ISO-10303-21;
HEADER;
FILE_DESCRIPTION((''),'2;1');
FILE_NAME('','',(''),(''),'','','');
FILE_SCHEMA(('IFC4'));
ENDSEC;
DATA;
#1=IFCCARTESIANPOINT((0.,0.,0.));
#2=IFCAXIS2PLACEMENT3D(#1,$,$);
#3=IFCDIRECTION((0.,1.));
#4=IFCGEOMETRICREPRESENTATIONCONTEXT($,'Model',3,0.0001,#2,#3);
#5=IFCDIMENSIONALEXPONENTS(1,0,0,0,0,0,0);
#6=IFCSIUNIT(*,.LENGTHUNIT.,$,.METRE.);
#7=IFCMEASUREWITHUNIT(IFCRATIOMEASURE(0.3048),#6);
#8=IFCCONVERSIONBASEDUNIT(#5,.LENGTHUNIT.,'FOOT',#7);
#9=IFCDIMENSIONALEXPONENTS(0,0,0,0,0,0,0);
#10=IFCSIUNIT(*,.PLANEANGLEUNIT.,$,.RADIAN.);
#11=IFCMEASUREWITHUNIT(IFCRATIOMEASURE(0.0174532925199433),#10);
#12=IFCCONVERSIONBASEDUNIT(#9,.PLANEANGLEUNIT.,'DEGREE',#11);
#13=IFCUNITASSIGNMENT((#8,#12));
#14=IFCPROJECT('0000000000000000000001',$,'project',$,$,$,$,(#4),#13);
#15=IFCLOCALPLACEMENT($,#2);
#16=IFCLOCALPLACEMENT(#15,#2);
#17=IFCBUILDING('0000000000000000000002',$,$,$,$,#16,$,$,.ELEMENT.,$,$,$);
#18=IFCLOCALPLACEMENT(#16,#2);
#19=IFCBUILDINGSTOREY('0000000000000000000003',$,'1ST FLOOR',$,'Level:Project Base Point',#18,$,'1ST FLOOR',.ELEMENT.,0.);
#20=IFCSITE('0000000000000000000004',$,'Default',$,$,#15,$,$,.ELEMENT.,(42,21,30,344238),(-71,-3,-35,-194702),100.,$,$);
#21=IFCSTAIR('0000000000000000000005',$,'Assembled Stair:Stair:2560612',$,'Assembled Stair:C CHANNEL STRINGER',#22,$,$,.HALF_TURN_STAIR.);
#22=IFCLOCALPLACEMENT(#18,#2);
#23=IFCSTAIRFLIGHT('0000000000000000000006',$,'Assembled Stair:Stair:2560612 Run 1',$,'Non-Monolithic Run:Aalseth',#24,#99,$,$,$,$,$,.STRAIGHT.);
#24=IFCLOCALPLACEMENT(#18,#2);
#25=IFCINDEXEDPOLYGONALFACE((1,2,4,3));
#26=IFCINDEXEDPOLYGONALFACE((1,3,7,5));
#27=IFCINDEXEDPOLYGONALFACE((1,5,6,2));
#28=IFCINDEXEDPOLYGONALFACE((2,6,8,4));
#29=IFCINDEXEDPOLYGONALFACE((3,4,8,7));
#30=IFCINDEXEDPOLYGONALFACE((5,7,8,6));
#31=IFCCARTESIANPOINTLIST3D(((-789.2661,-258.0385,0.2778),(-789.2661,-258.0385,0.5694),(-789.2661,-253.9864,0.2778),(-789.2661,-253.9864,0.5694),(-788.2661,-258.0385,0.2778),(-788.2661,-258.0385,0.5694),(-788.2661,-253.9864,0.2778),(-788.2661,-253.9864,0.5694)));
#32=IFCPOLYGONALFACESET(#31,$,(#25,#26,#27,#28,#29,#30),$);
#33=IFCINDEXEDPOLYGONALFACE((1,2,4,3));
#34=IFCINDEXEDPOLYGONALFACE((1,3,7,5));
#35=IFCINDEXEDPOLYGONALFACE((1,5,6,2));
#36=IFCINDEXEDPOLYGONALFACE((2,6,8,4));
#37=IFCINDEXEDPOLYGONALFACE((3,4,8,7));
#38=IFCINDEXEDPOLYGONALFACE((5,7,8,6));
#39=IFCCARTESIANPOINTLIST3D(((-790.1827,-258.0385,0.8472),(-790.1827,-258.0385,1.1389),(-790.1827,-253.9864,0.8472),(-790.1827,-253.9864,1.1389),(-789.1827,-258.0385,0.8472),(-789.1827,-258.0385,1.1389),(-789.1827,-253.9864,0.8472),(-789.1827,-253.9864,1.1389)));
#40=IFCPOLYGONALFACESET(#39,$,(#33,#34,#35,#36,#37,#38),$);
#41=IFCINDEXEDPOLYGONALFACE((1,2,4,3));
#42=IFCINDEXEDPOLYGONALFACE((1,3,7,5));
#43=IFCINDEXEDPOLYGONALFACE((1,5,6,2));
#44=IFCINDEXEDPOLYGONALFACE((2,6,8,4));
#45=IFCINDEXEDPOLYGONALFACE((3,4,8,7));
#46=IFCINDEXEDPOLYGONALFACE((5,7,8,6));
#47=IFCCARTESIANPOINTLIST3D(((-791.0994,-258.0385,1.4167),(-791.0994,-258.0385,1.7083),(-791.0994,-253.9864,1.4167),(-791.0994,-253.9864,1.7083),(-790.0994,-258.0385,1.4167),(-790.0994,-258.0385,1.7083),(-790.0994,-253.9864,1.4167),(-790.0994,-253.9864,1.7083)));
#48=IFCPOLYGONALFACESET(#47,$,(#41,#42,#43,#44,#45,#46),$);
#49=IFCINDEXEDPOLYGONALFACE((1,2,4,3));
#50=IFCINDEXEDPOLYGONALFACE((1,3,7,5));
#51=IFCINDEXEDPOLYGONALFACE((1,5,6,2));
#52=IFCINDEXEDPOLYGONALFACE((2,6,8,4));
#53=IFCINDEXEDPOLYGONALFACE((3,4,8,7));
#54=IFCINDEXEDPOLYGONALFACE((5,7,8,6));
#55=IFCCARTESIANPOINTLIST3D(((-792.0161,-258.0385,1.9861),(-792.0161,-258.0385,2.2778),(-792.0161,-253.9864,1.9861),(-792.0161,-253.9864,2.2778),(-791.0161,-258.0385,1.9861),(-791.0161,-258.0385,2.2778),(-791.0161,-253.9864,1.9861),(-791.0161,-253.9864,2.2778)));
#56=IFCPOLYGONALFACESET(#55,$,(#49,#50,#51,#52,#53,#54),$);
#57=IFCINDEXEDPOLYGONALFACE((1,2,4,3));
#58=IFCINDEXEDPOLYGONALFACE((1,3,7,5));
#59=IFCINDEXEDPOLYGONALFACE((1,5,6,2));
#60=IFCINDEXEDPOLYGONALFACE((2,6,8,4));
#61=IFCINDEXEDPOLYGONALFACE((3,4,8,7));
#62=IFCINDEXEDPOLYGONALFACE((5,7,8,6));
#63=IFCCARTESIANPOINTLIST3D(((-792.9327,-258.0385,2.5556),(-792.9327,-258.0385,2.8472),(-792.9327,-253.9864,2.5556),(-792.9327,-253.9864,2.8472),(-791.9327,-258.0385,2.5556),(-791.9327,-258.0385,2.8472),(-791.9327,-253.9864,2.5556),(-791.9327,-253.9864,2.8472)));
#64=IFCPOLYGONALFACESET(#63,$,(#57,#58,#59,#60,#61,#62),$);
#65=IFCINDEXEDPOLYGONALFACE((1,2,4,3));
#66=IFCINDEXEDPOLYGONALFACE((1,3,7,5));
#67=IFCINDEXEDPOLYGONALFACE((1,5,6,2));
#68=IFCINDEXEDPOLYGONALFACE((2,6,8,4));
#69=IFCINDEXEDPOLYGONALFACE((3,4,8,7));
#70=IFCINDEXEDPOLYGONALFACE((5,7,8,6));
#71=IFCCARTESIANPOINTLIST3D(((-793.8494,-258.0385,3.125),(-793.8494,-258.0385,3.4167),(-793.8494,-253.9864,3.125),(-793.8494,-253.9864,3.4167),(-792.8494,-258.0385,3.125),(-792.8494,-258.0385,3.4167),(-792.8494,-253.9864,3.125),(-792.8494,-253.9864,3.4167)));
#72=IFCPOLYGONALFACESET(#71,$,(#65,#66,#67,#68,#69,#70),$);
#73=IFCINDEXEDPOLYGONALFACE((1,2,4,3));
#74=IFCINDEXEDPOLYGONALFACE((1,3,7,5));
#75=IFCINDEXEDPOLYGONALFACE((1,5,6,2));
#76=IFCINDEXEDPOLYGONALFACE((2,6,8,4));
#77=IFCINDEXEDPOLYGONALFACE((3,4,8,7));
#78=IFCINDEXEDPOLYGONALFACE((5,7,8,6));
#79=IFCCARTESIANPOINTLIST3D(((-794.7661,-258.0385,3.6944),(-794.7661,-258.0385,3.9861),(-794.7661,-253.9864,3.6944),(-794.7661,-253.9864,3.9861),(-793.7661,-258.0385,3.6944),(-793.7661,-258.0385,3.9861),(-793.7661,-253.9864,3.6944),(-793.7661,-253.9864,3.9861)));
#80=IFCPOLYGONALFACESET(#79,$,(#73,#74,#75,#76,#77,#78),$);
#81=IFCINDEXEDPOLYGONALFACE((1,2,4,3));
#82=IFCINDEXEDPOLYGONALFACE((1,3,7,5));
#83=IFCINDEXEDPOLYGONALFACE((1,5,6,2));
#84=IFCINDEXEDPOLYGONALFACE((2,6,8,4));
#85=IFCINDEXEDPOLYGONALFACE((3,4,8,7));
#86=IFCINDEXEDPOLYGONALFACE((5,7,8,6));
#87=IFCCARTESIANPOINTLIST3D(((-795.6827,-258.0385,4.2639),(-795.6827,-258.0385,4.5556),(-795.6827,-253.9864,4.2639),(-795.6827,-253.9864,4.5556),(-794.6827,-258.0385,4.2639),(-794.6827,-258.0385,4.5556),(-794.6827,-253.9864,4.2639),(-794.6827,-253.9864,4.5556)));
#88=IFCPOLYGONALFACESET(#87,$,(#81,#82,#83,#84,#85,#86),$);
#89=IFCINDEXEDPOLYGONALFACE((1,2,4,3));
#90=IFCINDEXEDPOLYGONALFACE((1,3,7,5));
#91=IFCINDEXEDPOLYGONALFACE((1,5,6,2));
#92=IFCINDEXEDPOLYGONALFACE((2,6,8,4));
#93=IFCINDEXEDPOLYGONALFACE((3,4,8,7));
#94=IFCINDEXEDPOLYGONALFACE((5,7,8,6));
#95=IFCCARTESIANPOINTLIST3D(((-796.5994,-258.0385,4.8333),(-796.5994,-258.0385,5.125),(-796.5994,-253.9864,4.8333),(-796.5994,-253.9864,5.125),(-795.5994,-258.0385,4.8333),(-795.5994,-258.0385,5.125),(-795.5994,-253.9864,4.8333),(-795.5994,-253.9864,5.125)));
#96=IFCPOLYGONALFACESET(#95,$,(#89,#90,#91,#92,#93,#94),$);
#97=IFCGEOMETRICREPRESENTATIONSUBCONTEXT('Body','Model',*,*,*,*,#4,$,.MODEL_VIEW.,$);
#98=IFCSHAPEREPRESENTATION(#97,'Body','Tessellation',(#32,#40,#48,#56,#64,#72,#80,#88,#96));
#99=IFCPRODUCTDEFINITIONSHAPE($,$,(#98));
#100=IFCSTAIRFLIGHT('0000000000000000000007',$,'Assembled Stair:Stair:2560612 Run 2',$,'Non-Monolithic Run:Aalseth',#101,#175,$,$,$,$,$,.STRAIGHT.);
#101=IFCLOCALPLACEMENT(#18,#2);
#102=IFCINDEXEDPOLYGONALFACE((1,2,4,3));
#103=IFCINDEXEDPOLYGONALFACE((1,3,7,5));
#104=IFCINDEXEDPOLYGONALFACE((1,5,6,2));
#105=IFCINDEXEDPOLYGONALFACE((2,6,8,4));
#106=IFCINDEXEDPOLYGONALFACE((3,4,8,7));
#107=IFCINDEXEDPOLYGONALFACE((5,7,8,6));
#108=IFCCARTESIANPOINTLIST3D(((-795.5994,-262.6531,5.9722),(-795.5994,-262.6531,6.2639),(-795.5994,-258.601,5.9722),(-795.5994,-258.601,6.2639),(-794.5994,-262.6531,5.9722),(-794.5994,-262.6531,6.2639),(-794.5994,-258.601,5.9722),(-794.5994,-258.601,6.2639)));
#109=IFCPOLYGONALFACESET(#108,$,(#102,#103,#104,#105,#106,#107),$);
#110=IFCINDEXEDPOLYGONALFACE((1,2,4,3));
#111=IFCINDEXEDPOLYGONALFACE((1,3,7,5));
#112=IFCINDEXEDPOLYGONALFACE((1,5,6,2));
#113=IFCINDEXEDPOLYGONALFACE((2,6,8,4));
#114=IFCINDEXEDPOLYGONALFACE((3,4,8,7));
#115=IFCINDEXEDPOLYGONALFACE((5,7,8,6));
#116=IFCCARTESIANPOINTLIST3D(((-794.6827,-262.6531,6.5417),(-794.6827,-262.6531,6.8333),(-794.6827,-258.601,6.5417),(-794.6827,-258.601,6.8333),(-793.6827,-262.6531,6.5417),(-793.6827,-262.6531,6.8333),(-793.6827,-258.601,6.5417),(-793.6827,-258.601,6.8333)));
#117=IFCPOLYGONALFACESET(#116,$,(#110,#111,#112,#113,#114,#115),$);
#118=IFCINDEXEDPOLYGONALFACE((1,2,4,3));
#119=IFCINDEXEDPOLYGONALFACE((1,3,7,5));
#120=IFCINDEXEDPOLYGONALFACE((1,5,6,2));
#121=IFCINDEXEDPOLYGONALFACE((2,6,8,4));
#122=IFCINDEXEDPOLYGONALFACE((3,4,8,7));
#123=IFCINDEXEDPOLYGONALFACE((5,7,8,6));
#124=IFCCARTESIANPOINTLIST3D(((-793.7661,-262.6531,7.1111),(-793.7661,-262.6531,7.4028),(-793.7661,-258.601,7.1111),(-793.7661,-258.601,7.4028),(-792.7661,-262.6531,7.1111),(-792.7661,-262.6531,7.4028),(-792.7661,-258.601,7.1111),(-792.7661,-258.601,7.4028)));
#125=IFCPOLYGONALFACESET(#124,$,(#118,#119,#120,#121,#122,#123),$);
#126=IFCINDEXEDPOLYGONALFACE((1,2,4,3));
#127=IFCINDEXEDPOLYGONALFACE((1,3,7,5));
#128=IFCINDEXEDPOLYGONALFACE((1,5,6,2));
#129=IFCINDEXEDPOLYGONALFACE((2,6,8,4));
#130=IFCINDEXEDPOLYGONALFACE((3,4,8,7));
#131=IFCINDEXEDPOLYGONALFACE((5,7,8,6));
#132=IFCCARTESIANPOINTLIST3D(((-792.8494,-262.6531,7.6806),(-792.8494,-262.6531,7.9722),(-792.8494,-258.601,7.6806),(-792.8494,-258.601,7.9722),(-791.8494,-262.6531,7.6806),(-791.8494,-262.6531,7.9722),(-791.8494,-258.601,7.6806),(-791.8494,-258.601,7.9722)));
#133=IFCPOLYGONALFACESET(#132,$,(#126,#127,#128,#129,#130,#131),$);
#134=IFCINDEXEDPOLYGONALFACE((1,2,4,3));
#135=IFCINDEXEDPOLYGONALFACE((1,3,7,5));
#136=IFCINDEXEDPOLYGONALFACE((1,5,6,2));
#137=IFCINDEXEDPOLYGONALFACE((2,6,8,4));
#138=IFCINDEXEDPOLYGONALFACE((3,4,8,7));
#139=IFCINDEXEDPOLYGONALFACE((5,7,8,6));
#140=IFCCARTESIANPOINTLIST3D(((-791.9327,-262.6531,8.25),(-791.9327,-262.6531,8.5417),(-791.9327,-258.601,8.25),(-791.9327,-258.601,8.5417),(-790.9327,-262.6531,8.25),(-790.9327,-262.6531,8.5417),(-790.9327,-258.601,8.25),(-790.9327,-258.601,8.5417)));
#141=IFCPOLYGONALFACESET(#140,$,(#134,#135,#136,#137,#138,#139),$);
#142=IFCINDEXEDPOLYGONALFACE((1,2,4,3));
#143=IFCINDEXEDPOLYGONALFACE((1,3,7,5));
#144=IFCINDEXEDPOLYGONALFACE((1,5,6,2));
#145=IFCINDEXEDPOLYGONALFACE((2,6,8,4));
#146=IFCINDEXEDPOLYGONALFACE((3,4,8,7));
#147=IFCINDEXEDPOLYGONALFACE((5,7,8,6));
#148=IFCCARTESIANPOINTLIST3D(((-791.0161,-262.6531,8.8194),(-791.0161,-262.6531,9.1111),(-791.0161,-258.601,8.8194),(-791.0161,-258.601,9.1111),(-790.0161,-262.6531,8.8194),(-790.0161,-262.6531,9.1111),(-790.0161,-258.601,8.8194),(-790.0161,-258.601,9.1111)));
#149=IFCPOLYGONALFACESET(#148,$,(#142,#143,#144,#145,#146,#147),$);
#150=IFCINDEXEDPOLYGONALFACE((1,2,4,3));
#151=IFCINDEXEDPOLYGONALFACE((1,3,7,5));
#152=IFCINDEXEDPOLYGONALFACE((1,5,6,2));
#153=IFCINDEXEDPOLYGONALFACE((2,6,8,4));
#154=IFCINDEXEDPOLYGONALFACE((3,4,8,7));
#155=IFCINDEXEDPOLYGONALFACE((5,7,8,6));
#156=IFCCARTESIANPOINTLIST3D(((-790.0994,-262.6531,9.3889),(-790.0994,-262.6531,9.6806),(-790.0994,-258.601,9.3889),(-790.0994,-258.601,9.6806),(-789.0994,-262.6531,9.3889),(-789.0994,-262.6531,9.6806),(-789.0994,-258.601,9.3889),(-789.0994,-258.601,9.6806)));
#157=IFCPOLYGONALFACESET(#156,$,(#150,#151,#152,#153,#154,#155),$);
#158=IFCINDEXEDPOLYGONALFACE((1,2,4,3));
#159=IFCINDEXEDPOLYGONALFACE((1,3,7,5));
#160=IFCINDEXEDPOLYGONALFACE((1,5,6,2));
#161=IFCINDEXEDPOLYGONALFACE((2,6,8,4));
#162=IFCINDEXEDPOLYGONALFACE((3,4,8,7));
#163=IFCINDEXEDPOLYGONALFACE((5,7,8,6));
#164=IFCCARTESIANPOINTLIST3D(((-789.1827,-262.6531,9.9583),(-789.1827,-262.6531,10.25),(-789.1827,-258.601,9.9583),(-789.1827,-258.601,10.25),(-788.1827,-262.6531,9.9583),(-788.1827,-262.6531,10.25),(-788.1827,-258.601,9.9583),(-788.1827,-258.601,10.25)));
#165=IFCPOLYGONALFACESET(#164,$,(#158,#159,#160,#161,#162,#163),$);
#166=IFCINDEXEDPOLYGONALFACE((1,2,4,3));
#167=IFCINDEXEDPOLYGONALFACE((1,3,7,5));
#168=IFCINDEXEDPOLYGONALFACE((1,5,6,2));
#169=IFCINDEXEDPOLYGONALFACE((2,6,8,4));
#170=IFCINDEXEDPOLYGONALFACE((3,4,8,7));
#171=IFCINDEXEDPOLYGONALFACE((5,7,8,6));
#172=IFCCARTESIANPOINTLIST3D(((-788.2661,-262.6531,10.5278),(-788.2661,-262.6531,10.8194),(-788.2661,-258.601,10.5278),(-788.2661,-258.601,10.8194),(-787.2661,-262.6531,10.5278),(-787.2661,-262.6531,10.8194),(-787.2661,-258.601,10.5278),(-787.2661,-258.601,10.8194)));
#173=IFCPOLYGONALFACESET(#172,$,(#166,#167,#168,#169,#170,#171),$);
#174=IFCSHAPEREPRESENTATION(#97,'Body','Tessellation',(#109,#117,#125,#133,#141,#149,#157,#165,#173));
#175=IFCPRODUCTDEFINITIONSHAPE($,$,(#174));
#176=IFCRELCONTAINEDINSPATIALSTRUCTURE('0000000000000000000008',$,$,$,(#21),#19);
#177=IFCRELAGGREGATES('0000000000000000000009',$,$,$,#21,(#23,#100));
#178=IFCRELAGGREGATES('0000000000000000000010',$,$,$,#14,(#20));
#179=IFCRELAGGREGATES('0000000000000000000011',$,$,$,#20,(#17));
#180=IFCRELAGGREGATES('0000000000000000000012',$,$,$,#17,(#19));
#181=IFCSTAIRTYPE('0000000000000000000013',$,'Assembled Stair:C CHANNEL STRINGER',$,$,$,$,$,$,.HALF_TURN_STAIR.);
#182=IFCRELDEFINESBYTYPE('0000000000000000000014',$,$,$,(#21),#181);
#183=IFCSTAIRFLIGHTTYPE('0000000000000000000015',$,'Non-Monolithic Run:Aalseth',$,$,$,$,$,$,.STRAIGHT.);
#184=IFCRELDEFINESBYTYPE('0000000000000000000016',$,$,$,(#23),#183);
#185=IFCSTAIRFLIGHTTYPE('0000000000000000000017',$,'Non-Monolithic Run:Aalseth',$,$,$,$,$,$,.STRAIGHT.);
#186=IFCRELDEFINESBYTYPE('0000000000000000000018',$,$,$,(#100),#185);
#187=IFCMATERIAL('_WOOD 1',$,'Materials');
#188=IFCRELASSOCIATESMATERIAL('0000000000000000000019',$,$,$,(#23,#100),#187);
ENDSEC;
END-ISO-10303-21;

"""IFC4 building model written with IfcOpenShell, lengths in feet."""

from ifc_helpers import new_model, entity, si_unit, converted_unit, direction, frame, frame_2d, origin, place, context, subcontext, project, spatial, rectangle, extrude, material, type_object, element, aggregate, save


model = new_model("IFC4")

# Units and contexts
model_context = context("Model", 3, precision=0.0001, world=origin(), true_north=direction((0.0, 1.0)))
body_context = subcontext(model_context, "Body", "Model", "MODEL_VIEW")
ifc_project = project(units=[converted_unit("LENGTHUNIT", "FOOT", entity("IfcRatioMeasure", 0.3048), si_unit("LENGTHUNIT", "METRE"), dimensions=[1, 0, 0, 0, 0, 0, 0]), converted_unit("PLANEANGLEUNIT", "DEGREE", entity("IfcRatioMeasure", 0.0174532925199433), si_unit("PLANEANGLEUNIT", "RADIAN"), dimensions=[0, 0, 0, 0, 0, 0, 0])], contexts=[model_context])

# Site, building, storey
site_placement = place(None, origin())
site = spatial("IfcSite", under=ifc_project, at=site_placement, Name="Default", CompositionType="ELEMENT", RefLatitude=(42, 21, 30, 344238), RefLongitude=(-71, -3, -35, -194702), RefElevation=100.0)
building_placement = place(site_placement, origin())
building = spatial("IfcBuilding", under=site, at=building_placement, CompositionType="ELEMENT")
storey_placement = place(building_placement, origin())
storey = spatial("IfcBuildingStorey", under=building, at=storey_placement, Name="1ST FLOOR", ObjectType="Level:Project Base Point", LongName="1ST FLOOR", CompositionType="ELEMENT", Elevation=0.0)

# Stair
stair_type_1 = type_object("IfcStairType", Name="Assembled Stair:C CHANNEL STRINGER", PredefinedType="HALF_TURN_STAIR")
stair_1_placement = place(storey_placement, origin())
stair_1 = element("IfcStair", 1, at=stair_1_placement, inside=storey, type_object=stair_type_1, Name="Assembled Stair:Stair:2560612", ObjectType="Assembled Stair:C CHANNEL STRINGER", PredefinedType="HALF_TURN_STAIR")

# Shared definitions
ifc_material_1 = material(Name="_WOOD 1", Category="Materials")

# Stair flights
stair_flight_type_1 = type_object("IfcStairFlightType", Name="Non-Monolithic Run:Aalseth", PredefinedType="STRAIGHT")
stair_flight_1_placement = place(stair_1_placement, frame((-796.5994, -258.0385, 0.0)))
stair_flight_1 = element("IfcStairFlight", 2, at=stair_flight_1_placement, type_object=stair_flight_type_1, material=ifc_material_1, Name="Assembled Stair:Stair:2560612 Run 1", ObjectType="Non-Monolithic Run:Aalseth", PredefinedType="STRAIGHT", context=body_context, shape_type="SweptSolid", body=[
    extrude(rectangle(XDim=1.0, YDim=4.0521, at=frame_2d((0.0, 0.0), x_axis=(1.0, 0.0))), frame((7.8333, 2.026, 0.2778)), (0.0, 0.0, 1.0), 0.2917),
    extrude(rectangle(XDim=1.0, YDim=4.0521, at=frame_2d((0.0, 0.0), x_axis=(1.0, 0.0))), frame((6.9167, 2.026, 0.8472)), (0.0, 0.0, 1.0), 0.2917),
    extrude(rectangle(XDim=1.0, YDim=4.0521, at=frame_2d((0.0, 0.0), x_axis=(1.0, 0.0))), frame((6.0, 2.026, 1.4167)), (0.0, 0.0, 1.0), 0.2917),
    extrude(rectangle(XDim=1.0, YDim=4.0521, at=frame_2d((0.0, 0.0), x_axis=(1.0, 0.0))), frame((5.0833, 2.026, 1.9861)), (0.0, 0.0, 1.0), 0.2917),
    extrude(rectangle(XDim=1.0, YDim=4.0521, at=frame_2d((0.0, 0.0), x_axis=(1.0, 0.0))), frame((4.1667, 2.026, 2.5556)), (0.0, 0.0, 1.0), 0.2917),
    extrude(rectangle(XDim=1.0, YDim=4.0521, at=frame_2d((0.0, 0.0), x_axis=(1.0, 0.0))), frame((3.25, 2.026, 3.125)), (0.0, 0.0, 1.0), 0.2917),
    extrude(rectangle(XDim=1.0, YDim=4.0521, at=frame_2d((0.0, 0.0), x_axis=(1.0, 0.0))), frame((2.3333, 2.026, 3.6944)), (0.0, 0.0, 1.0), 0.2917),
    extrude(rectangle(XDim=1.0, YDim=4.0521, at=frame_2d((0.0, 0.0), x_axis=(1.0, 0.0))), frame((1.4167, 2.026, 4.2639)), (0.0, 0.0, 1.0), 0.2917),
    extrude(rectangle(XDim=1.0, YDim=4.0521, at=frame_2d((0.0, 0.0), x_axis=(1.0, 0.0))), frame((0.5, 2.026, 4.8333)), (0.0, 0.0, 1.0), 0.2917),
])
stair_flight_type_2 = type_object("IfcStairFlightType", Name="Non-Monolithic Run:Aalseth", PredefinedType="STRAIGHT")
stair_flight_2_placement = place(stair_1_placement, frame((-795.5994, -262.6531, 0.0)))
stair_flight_2 = element("IfcStairFlight", 3, at=stair_flight_2_placement, type_object=stair_flight_type_2, material=ifc_material_1, Name="Assembled Stair:Stair:2560612 Run 2", ObjectType="Non-Monolithic Run:Aalseth", PredefinedType="STRAIGHT", context=body_context, shape_type="SweptSolid", body=[
    extrude(rectangle(XDim=1.0, YDim=4.0521, at=frame_2d((0.0, 0.0), x_axis=(1.0, 0.0))), frame((0.5, 2.026, 5.9722), z_axis=(0.0, 0.0, 1.0), x_axis=(-1.0, 0.0, 0.0)), (0.0, 0.0, 1.0), 0.2917),
    extrude(rectangle(XDim=1.0, YDim=4.0521, at=frame_2d((0.0, 0.0), x_axis=(1.0, 0.0))), frame((1.4167, 2.026, 6.5417), z_axis=(0.0, 0.0, 1.0), x_axis=(-1.0, 0.0, 0.0)), (0.0, 0.0, 1.0), 0.2917),
    extrude(rectangle(XDim=1.0, YDim=4.0521, at=frame_2d((0.0, 0.0), x_axis=(1.0, 0.0))), frame((2.3333, 2.026, 7.1111), z_axis=(0.0, 0.0, 1.0), x_axis=(-1.0, 0.0, 0.0)), (0.0, 0.0, 1.0), 0.2917),
    extrude(rectangle(XDim=1.0, YDim=4.0521, at=frame_2d((0.0, 0.0), x_axis=(1.0, 0.0))), frame((3.25, 2.026, 7.6806), z_axis=(0.0, 0.0, 1.0), x_axis=(-1.0, 0.0, 0.0)), (0.0, 0.0, 1.0), 0.2917),
    extrude(rectangle(XDim=1.0, YDim=4.0521, at=frame_2d((0.0, 0.0), x_axis=(1.0, 0.0))), frame((4.1667, 2.026, 8.25), z_axis=(0.0, 0.0, 1.0), x_axis=(-1.0, 0.0, 0.0)), (0.0, 0.0, 1.0), 0.2917),
    extrude(rectangle(XDim=1.0, YDim=4.0521, at=frame_2d((0.0, 0.0), x_axis=(1.0, 0.0))), frame((5.0833, 2.026, 8.8194), z_axis=(0.0, 0.0, 1.0), x_axis=(-1.0, 0.0, 0.0)), (0.0, 0.0, 1.0), 0.2917),
    extrude(rectangle(XDim=1.0, YDim=4.0521, at=frame_2d((0.0, 0.0), x_axis=(1.0, 0.0))), frame((6.0, 2.026, 9.3889), z_axis=(0.0, 0.0, 1.0), x_axis=(-1.0, 0.0, 0.0)), (0.0, 0.0, 1.0), 0.2917),
    extrude(rectangle(XDim=1.0, YDim=4.0521, at=frame_2d((0.0, 0.0), x_axis=(1.0, 0.0))), frame((6.9167, 2.026, 9.9583), z_axis=(0.0, 0.0, 1.0), x_axis=(-1.0, 0.0, 0.0)), (0.0, 0.0, 1.0), 0.2917),
    extrude(rectangle(XDim=1.0, YDim=4.0521, at=frame_2d((0.0, 0.0), x_axis=(1.0, 0.0))), frame((7.8333, 2.026, 10.5278), z_axis=(0.0, 0.0, 1.0), x_axis=(-1.0, 0.0, 0.0)), (0.0, 0.0, 1.0), 0.2917),
])
aggregate(stair_1, [stair_flight_1, stair_flight_2])

save(model, "model.ifc")
